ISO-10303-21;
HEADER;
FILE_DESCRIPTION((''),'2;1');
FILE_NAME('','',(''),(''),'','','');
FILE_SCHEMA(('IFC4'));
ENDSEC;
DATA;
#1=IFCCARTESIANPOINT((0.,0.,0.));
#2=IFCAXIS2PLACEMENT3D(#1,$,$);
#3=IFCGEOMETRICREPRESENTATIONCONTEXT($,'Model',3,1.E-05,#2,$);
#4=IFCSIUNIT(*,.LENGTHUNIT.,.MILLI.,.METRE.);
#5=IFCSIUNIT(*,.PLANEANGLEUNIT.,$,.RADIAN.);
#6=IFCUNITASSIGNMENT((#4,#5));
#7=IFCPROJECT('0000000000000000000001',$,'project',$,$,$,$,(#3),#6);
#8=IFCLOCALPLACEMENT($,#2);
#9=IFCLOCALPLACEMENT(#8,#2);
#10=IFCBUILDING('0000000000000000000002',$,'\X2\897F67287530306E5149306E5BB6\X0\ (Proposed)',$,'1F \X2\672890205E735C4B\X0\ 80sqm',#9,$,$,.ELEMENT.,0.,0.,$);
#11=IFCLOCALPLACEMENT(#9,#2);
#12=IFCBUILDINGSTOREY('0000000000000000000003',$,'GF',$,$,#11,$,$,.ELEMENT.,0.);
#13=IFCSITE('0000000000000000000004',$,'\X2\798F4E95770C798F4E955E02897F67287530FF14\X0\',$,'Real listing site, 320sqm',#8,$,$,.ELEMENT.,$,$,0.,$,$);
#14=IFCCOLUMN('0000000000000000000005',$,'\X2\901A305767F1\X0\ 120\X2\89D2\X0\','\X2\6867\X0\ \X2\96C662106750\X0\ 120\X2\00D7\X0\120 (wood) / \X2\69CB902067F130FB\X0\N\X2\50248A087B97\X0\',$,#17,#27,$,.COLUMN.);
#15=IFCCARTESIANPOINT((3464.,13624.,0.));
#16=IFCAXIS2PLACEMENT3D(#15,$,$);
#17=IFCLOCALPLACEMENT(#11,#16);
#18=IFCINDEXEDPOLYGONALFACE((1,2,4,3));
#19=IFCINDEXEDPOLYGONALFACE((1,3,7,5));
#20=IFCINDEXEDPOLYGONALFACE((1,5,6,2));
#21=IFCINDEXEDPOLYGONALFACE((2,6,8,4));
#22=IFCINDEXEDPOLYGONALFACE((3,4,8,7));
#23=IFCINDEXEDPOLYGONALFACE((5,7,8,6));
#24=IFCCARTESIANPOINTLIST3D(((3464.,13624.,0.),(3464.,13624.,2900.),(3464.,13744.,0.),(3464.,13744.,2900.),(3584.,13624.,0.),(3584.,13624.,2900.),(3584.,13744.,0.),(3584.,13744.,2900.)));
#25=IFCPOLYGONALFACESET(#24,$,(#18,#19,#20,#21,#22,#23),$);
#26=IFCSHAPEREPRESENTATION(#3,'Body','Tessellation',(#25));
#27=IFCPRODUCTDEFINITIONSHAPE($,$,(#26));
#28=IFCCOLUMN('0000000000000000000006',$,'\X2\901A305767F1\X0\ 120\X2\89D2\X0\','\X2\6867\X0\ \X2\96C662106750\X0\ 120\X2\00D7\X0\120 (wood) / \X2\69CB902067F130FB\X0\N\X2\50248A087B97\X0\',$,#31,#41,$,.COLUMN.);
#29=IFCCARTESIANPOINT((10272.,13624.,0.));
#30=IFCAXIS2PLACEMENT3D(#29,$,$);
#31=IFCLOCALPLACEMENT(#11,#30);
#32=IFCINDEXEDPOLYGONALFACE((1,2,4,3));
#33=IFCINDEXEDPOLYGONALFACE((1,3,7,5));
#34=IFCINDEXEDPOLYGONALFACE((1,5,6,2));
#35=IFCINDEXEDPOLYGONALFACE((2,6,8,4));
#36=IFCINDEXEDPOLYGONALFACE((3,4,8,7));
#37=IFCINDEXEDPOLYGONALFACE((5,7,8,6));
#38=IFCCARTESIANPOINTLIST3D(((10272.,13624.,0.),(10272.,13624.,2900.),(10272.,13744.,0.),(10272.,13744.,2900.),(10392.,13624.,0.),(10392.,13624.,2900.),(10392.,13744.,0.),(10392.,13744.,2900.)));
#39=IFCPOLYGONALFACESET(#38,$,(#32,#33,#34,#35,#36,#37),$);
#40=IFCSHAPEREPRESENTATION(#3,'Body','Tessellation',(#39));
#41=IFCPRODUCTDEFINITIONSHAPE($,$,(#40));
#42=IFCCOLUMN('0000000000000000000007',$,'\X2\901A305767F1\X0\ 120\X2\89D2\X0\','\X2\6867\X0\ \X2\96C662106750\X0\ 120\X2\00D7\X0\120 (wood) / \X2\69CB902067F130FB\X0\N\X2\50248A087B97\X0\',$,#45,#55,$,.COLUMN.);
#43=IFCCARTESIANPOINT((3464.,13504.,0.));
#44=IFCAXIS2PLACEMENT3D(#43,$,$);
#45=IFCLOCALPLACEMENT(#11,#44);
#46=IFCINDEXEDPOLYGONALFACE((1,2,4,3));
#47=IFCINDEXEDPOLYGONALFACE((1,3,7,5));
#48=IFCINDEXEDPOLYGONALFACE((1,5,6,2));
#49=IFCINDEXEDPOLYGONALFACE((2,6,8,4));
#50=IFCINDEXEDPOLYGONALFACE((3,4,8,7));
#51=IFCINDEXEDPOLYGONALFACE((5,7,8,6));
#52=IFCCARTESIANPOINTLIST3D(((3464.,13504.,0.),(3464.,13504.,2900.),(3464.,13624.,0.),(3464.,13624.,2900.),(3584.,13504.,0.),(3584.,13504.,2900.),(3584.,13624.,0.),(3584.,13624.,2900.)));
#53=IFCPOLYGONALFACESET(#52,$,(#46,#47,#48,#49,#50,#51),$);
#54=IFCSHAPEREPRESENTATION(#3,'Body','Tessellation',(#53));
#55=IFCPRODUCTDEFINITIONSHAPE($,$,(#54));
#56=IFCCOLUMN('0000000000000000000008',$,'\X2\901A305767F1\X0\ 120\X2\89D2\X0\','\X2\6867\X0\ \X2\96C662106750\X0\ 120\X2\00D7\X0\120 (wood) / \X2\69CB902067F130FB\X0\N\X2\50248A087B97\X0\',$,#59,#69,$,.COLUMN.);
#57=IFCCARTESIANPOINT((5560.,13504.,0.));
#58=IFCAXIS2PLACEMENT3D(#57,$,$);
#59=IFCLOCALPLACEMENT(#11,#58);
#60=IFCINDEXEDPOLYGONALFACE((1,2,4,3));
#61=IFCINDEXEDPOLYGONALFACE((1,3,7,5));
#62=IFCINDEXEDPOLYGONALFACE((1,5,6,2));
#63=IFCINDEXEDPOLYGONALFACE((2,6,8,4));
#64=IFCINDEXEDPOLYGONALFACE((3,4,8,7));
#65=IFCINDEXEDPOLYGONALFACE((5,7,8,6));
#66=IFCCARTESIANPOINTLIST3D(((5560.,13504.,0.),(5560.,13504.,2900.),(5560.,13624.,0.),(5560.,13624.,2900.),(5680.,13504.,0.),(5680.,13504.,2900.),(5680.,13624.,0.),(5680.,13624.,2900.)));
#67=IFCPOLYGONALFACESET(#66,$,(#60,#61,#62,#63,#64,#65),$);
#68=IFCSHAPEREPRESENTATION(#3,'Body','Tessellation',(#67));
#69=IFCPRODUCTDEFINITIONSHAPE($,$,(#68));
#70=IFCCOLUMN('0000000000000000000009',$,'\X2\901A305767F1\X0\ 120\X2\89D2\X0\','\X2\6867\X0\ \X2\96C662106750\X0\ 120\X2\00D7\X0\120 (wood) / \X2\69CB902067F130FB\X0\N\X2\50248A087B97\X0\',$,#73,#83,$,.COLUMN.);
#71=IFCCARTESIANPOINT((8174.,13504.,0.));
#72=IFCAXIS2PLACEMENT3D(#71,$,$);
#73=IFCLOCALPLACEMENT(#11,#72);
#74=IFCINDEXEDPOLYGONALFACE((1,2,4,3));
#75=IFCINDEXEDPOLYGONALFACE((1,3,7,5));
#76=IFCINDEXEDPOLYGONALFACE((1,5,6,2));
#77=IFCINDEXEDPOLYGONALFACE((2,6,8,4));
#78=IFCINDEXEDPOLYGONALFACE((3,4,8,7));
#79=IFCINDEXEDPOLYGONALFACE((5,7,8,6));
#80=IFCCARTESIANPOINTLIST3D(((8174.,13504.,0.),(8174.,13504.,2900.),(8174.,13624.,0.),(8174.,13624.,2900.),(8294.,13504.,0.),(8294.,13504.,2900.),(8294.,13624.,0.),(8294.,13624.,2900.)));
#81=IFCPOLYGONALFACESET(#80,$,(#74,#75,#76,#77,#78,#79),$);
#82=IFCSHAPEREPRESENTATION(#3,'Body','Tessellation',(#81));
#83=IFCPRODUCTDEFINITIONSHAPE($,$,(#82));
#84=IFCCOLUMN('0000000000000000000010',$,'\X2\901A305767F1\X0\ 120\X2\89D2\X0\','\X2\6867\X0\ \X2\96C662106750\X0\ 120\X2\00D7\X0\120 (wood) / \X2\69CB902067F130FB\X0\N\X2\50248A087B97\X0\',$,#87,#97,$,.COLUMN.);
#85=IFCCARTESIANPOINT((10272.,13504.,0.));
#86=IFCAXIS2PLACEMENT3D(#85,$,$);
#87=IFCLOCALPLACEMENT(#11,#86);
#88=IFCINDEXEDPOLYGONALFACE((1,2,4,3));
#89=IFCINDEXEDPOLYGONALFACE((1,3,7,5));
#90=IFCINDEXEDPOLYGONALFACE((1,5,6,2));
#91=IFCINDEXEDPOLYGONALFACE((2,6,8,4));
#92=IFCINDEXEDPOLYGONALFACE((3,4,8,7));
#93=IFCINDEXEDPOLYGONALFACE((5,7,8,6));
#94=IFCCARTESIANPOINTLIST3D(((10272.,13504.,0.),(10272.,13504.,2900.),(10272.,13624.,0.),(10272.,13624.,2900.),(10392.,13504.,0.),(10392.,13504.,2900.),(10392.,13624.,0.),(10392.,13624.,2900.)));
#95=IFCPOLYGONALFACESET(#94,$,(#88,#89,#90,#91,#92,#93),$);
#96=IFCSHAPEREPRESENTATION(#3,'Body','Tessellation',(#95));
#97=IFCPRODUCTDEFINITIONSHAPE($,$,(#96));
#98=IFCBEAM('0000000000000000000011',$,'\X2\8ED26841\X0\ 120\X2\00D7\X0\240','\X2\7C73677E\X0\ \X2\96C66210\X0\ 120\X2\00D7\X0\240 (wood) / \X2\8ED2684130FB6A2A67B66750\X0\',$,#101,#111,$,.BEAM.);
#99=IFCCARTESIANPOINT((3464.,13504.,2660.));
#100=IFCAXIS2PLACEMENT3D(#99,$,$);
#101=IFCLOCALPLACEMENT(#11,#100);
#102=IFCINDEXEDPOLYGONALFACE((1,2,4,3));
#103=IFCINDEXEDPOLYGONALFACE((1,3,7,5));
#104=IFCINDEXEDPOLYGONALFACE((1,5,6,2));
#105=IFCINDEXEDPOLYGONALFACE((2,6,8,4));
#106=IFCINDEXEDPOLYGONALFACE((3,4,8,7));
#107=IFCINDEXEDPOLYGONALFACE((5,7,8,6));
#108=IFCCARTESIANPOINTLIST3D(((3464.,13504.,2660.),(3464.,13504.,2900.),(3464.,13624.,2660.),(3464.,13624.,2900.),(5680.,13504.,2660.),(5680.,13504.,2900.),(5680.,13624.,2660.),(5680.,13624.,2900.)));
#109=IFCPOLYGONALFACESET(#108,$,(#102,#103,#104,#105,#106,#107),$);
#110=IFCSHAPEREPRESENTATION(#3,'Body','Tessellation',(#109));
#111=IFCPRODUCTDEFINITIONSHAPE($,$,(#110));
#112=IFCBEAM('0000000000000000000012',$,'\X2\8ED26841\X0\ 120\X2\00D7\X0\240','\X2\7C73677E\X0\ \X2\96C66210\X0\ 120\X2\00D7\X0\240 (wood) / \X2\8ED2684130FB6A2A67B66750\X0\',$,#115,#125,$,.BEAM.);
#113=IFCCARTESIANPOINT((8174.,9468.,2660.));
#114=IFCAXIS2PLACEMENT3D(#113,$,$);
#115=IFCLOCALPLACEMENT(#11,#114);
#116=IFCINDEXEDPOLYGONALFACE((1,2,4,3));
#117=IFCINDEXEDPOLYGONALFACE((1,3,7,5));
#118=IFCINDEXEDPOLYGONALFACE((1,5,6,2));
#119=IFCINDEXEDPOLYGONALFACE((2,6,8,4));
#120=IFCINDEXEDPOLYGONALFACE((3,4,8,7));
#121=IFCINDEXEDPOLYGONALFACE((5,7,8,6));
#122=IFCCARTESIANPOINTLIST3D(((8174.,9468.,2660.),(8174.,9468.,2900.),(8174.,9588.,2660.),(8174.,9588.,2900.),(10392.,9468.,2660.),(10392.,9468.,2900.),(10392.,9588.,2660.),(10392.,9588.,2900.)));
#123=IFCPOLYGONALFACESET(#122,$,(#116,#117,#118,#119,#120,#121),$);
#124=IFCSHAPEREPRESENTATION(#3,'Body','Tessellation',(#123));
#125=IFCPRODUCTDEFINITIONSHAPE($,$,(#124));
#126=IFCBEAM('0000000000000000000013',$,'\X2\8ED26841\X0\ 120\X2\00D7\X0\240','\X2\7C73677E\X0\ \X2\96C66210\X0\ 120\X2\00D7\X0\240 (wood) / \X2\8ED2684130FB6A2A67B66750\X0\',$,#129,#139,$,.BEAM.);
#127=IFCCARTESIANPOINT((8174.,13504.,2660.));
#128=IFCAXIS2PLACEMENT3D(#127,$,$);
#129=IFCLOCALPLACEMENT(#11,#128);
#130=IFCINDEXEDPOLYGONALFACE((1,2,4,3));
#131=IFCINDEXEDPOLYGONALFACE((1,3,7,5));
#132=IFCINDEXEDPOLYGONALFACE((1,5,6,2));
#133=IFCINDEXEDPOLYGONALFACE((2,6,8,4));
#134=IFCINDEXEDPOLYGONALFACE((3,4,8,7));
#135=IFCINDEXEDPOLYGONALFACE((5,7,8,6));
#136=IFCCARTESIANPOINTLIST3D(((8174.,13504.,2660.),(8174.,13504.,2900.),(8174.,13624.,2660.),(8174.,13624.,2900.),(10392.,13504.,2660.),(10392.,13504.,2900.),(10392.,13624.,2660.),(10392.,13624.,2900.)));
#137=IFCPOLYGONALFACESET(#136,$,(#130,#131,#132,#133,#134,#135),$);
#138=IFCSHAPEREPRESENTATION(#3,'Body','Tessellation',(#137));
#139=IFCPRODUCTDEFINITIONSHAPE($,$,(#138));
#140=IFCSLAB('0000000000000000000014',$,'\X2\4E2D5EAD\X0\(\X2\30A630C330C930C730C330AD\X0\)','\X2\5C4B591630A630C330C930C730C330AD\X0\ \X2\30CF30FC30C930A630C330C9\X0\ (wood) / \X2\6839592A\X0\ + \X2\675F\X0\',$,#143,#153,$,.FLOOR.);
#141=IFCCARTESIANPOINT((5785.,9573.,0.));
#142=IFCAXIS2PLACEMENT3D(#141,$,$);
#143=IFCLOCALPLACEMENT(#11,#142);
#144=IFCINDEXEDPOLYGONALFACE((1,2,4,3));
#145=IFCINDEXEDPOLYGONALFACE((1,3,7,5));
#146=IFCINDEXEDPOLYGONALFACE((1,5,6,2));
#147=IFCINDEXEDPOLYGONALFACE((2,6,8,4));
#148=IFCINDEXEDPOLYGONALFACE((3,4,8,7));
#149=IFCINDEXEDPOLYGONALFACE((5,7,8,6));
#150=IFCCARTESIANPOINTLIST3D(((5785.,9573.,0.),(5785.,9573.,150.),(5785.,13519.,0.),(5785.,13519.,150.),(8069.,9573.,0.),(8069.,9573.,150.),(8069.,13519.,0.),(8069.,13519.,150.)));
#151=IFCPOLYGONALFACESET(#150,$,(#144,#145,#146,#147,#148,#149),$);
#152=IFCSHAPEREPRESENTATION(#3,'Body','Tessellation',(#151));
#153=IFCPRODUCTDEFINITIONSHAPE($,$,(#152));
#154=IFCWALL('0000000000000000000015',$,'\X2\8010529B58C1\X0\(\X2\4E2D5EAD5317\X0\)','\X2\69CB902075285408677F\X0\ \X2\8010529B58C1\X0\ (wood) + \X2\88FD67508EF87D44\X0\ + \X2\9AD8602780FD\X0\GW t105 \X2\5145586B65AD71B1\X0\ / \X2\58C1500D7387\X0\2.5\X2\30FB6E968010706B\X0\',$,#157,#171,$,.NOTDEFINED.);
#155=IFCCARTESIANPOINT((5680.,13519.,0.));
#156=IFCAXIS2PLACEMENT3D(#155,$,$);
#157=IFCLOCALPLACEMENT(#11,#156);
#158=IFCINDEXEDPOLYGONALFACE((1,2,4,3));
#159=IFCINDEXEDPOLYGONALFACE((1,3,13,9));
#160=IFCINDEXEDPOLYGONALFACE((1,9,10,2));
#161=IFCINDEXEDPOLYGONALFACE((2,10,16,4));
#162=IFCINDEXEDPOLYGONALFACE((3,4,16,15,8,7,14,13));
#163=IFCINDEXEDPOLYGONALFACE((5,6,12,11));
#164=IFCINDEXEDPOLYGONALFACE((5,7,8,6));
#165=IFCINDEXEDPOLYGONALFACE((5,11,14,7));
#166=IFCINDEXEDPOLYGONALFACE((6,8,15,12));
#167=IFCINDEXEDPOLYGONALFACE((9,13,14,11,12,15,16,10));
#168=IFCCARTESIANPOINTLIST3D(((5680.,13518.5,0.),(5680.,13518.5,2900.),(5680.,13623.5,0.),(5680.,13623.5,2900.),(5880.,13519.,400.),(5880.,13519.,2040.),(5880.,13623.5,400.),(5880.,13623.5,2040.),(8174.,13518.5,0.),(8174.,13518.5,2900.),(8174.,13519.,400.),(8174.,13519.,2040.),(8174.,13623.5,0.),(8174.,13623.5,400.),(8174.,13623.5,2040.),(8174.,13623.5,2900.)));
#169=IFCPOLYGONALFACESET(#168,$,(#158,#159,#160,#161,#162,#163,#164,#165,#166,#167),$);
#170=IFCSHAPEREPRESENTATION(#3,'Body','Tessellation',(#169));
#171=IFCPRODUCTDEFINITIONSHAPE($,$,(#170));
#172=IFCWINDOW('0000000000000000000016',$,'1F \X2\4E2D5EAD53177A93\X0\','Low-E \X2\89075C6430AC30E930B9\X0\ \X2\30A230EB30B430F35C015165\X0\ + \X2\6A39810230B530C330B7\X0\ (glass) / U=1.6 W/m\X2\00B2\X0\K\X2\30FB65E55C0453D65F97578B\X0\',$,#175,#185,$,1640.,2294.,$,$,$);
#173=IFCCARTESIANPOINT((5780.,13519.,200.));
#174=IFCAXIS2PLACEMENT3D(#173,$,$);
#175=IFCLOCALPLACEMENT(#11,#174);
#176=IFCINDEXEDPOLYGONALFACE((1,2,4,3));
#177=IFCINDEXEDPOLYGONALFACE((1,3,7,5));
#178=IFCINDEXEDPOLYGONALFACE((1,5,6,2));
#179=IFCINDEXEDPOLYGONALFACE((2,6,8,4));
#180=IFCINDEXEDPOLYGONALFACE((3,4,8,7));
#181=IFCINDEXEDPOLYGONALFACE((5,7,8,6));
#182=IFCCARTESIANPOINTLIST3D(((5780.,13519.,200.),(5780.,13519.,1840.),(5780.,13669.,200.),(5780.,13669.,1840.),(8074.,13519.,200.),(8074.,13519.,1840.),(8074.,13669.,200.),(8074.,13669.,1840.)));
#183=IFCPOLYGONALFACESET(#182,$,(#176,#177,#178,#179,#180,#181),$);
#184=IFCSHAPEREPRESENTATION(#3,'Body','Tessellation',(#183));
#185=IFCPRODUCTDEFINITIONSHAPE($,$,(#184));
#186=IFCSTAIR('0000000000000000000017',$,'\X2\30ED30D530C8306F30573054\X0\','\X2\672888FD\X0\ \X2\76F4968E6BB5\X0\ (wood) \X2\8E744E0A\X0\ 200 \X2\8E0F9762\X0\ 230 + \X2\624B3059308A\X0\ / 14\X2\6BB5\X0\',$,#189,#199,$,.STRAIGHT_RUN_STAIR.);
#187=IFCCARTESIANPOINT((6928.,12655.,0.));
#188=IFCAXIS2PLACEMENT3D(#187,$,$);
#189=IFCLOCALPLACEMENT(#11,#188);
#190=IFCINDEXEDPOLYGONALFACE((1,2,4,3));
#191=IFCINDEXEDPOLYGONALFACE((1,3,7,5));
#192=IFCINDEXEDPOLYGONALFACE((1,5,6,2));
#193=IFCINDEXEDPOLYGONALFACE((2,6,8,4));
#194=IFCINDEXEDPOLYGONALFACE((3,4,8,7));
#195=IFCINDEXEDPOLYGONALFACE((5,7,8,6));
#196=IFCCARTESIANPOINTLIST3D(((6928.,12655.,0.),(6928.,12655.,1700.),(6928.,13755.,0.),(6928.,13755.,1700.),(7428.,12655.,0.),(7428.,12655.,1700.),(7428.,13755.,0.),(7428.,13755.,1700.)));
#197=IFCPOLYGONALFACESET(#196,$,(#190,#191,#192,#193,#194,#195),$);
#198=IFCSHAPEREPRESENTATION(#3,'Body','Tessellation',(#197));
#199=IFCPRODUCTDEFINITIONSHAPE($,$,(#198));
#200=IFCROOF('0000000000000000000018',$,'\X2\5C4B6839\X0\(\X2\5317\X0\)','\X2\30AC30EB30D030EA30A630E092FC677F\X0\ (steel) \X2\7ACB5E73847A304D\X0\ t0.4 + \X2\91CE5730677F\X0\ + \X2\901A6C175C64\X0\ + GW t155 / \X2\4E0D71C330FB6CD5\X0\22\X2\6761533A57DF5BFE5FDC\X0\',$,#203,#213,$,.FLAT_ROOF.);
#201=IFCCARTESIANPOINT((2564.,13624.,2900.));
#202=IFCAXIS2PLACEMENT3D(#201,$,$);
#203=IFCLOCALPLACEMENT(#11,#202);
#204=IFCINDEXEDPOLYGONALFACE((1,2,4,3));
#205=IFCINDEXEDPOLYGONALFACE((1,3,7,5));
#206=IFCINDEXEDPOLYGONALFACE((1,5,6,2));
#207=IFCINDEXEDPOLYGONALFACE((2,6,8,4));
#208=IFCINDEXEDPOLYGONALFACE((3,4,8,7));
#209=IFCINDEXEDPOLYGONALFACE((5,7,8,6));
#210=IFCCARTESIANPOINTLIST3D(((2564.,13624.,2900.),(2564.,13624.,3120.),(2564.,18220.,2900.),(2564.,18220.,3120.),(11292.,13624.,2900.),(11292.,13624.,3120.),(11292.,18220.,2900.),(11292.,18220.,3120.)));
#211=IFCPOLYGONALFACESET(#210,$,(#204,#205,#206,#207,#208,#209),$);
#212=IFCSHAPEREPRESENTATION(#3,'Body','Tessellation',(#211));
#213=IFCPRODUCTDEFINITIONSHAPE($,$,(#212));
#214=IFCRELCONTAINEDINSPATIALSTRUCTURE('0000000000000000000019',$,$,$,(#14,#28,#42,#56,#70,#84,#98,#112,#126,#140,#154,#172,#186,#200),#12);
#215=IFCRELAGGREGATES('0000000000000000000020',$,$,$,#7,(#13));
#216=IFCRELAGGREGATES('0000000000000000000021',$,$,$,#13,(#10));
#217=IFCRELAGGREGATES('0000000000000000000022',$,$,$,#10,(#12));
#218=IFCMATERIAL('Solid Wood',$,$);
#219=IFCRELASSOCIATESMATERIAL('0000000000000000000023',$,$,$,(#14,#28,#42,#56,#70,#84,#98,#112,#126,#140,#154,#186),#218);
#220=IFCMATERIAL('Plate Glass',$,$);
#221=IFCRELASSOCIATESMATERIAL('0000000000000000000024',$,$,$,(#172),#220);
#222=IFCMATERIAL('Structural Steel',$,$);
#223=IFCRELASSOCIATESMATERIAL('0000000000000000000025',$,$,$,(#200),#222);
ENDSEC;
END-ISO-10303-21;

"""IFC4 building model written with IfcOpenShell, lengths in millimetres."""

from ifc_helpers import new_model, si_unit, frame, frame_2d, origin, place, context, project, spatial, rectangle, extrude, material, element, fill, save


model = new_model("IFC4")

# Units and contexts
model_context = context("Model", 3, precision=1e-05, world=origin())
ifc_project = project(units=[si_unit("LENGTHUNIT", "METRE", prefix="MILLI"), si_unit("PLANEANGLEUNIT", "RADIAN")], contexts=[model_context])

# Site, building, storey
site_placement = place(None, origin())
site = spatial("IfcSite", under=ifc_project, at=site_placement, Name="福井県福井市西木田４", ObjectType="Real listing site, 320sqm", CompositionType="ELEMENT", RefElevation=0.0)
building_placement = place(site_placement, origin())
building = spatial("IfcBuilding", under=site, at=building_placement, Name="西木田の光の家 (Proposed)", ObjectType="1F 木造平屋 80sqm", CompositionType="ELEMENT", ElevationOfRefHeight=0.0, ElevationOfTerrain=0.0)
storey_placement = place(building_placement, origin())
storey = spatial("IfcBuildingStorey", under=building, at=storey_placement, Name="GF", CompositionType="ELEMENT", Elevation=0.0)

# Columns
ifc_material_1 = material(Name="Solid Wood")
column_1_placement = place(storey_placement, frame((3464.0, 13624.0, 0.0)))
element("IfcColumn", 1, at=column_1_placement, inside=storey, material=ifc_material_1, Name="通し柱 120角", Description="桧 集成材 120×120 (wood) / 構造柱・N値計算", PredefinedType="COLUMN", context=model_context, shape_type="SweptSolid", body=[
    extrude(rectangle(XDim=120.0, YDim=120.0, at=frame_2d((60.0, 60.0))), frame((3464.0, 13624.0, 0.0)), (0.0, 0.0, 1.0), 2900.0),
])
column_2_placement = place(storey_placement, frame((10272.0, 13624.0, 0.0)))
element("IfcColumn", 2, at=column_2_placement, inside=storey, material=ifc_material_1, Name="通し柱 120角", Description="桧 集成材 120×120 (wood) / 構造柱・N値計算", PredefinedType="COLUMN", context=model_context, shape_type="SweptSolid", body=[
    extrude(rectangle(XDim=120.0, YDim=120.0, at=frame_2d((60.0, 60.0))), frame((10272.0, 13624.0, 0.0)), (0.0, 0.0, 1.0), 2900.0),
])
column_3_placement = place(storey_placement, frame((3464.0, 13504.0, 0.0)))
element("IfcColumn", 3, at=column_3_placement, inside=storey, material=ifc_material_1, Name="通し柱 120角", Description="桧 集成材 120×120 (wood) / 構造柱・N値計算", PredefinedType="COLUMN", context=model_context, shape_type="SweptSolid", body=[
    extrude(rectangle(XDim=120.0, YDim=120.0, at=frame_2d((60.0, 60.0))), frame((3464.0, 13504.0, 0.0)), (0.0, 0.0, 1.0), 2900.0),
])
column_4_placement = place(storey_placement, frame((5560.0, 13504.0, 0.0)))
element("IfcColumn", 4, at=column_4_placement, inside=storey, material=ifc_material_1, Name="通し柱 120角", Description="桧 集成材 120×120 (wood) / 構造柱・N値計算", PredefinedType="COLUMN", context=model_context, shape_type="SweptSolid", body=[
    extrude(rectangle(XDim=120.0, YDim=120.0, at=frame_2d((60.0, 60.0))), frame((5560.0, 13504.0, 0.0)), (0.0, 0.0, 1.0), 2900.0),
])
column_5_placement = place(storey_placement, frame((8174.0, 13504.0, 0.0)))
element("IfcColumn", 5, at=column_5_placement, inside=storey, material=ifc_material_1, Name="通し柱 120角", Description="桧 集成材 120×120 (wood) / 構造柱・N値計算", PredefinedType="COLUMN", context=model_context, shape_type="SweptSolid", body=[
    extrude(rectangle(XDim=120.0, YDim=120.0, at=frame_2d((60.0, 60.0))), frame((8174.0, 13504.0, 0.0)), (0.0, 0.0, 1.0), 2900.0),
])
column_6_placement = place(storey_placement, frame((10272.0, 13504.0, 0.0)))
element("IfcColumn", 6, at=column_6_placement, inside=storey, material=ifc_material_1, Name="通し柱 120角", Description="桧 集成材 120×120 (wood) / 構造柱・N値計算", PredefinedType="COLUMN", context=model_context, shape_type="SweptSolid", body=[
    extrude(rectangle(XDim=120.0, YDim=120.0, at=frame_2d((60.0, 60.0))), frame((10272.0, 13504.0, 0.0)), (0.0, 0.0, 1.0), 2900.0),
])

# Beams
beam_1_placement = place(storey_placement, frame((3464.0, 13504.0, 2660.0)))
element("IfcBeam", 7, at=beam_1_placement, inside=storey, material=ifc_material_1, Name="軒桁 120×240", Description="米松 集成 120×240 (wood) / 軒桁・横架材", PredefinedType="BEAM", context=model_context, shape_type="SweptSolid", body=[
    extrude(rectangle(XDim=2216.0, YDim=120.0, at=frame_2d((1108.0, 60.0))), frame((3464.0, 13504.0, 2660.0)), (0.0, 0.0, 1.0), 240.0),
])
beam_2_placement = place(storey_placement, frame((8174.0, 9468.0, 2660.0)))
element("IfcBeam", 8, at=beam_2_placement, inside=storey, material=ifc_material_1, Name="軒桁 120×240", Description="米松 集成 120×240 (wood) / 軒桁・横架材", PredefinedType="BEAM", context=model_context, shape_type="SweptSolid", body=[
    extrude(rectangle(XDim=2218.0, YDim=120.0, at=frame_2d((1109.0, 60.0))), frame((8174.0, 9468.0, 2660.0)), (0.0, 0.0, 1.0), 240.0),
])
beam_3_placement = place(storey_placement, frame((8174.0, 13504.0, 2660.0)))
element("IfcBeam", 9, at=beam_3_placement, inside=storey, material=ifc_material_1, Name="軒桁 120×240", Description="米松 集成 120×240 (wood) / 軒桁・横架材", PredefinedType="BEAM", context=model_context, shape_type="SweptSolid", body=[
    extrude(rectangle(XDim=2218.0, YDim=120.0, at=frame_2d((1109.0, 60.0))), frame((8174.0, 13504.0, 2660.0)), (0.0, 0.0, 1.0), 240.0),
])

# Slab
slab_1_placement = place(storey_placement, frame((5785.0, 9573.0, 0.0)))
element("IfcSlab", 10, at=slab_1_placement, inside=storey, material=ifc_material_1, Name="中庭(ウッドデッキ)", Description="屋外ウッドデッキ ハードウッド (wood) / 根太 + 束", PredefinedType="FLOOR", context=model_context, shape_type="SweptSolid", body=[
    extrude(rectangle(XDim=2284.0, YDim=3946.0, at=frame_2d((1142.0, 1973.0))), frame((5785.0, 9573.0, 0.0)), (0.0, 0.0, 1.0), 150.0),
])

# Wall, opening, window
wall_placement = place(storey_placement, frame((5680.0, 13519.0, 0.0)))
wall = element("IfcWall", 11, at=wall_placement, inside=storey, material=ifc_material_1, Name="耐力壁(中庭北)", Description="構造用合板 耐力壁 (wood) + 製材軸組 + 高性能GW t105 充填断熱 / 壁倍率2.5・準耐火", PredefinedType="NOTDEFINED", context=model_context, shape_type="SweptSolid", body=[
    extrude(rectangle(XDim=2494.0, YDim=105.0, at=frame_2d((1247.0, 52.0))), frame((5680.0, 13519.0, 0.0)), (0.0, 0.0, 1.0), 2900.0),
])
opening_placement = place(storey_placement, frame((5780.0, 13519.0, 200.0)))
opening = element("IfcOpeningElement", 12, at=opening_placement, cuts=wall, PredefinedType="NOTDEFINED", context=model_context, shape_type="SweptSolid", body=[
    extrude(rectangle(XDim=2294.0, YDim=150.0, at=frame_2d((1147.0, 75.0))), frame((5780.0, 13519.0, 200.0)), (0.0, 0.0, 1.0), 1640.0),
])
ifc_material_2 = material(Name="Plate Glass")
window_placement = place(storey_placement, frame((5780.0, 13519.0, 200.0)))
window = element("IfcWindow", 13, at=window_placement, inside=storey, material=ifc_material_2, Name="1F 中庭北窓", Description="Low-E 複層ガラス アルゴン封入 + 樹脂サッシ (glass) / U=1.6 W/m²K・日射取得型", OverallHeight=1640.0, OverallWidth=2294.0, context=model_context, shape_type="SweptSolid", body=[
    extrude(rectangle(XDim=2294.0, YDim=150.0, at=frame_2d((1147.0, 75.0))), frame((5780.0, 13519.0, 200.0)), (0.0, 0.0, 1.0), 1640.0),
])
fill(opening, window)

# Stair
stair_placement = place(storey_placement, frame((6928.0, 12655.0, 0.0)))
element("IfcStair", 14, at=stair_placement, inside=storey, material=ifc_material_1, Name="ロフトはしご", Description="木製 直階段 (wood) 蹴上 200 踏面 230 + 手すり / 14段", PredefinedType="STRAIGHT_RUN_STAIR", context=model_context, shape_type="SweptSolid", body=[
    extrude(rectangle(XDim=500.0, YDim=1100.0, at=frame_2d((250.0, 550.0))), frame((6928.0, 12655.0, 0.0)), (0.0, 0.0, 1.0), 1700.0),
])

# Roof
ifc_material_3 = material(Name="Structural Steel")
roof_placement = place(storey_placement, frame((2564.0, 13624.0, 2900.0)))
element("IfcRoof", 15, at=roof_placement, inside=storey, material=ifc_material_3, Name="屋根(北)", Description="ガルバリウム鋼板 (steel) 立平葺き t0.4 + 野地板 + 通気層 + GW t155 / 不燃・法22条区域対応", PredefinedType="FLAT_ROOF", context=model_context, shape_type="SweptSolid", body=[
    extrude(rectangle(XDim=8728.0, YDim=4596.0, at=frame_2d((4364.0, 2298.0))), frame((2564.0, 13624.0, 2900.0)), (0.0, 0.0, 1.0), 220.0),
])

save(model, "model.ifc")
